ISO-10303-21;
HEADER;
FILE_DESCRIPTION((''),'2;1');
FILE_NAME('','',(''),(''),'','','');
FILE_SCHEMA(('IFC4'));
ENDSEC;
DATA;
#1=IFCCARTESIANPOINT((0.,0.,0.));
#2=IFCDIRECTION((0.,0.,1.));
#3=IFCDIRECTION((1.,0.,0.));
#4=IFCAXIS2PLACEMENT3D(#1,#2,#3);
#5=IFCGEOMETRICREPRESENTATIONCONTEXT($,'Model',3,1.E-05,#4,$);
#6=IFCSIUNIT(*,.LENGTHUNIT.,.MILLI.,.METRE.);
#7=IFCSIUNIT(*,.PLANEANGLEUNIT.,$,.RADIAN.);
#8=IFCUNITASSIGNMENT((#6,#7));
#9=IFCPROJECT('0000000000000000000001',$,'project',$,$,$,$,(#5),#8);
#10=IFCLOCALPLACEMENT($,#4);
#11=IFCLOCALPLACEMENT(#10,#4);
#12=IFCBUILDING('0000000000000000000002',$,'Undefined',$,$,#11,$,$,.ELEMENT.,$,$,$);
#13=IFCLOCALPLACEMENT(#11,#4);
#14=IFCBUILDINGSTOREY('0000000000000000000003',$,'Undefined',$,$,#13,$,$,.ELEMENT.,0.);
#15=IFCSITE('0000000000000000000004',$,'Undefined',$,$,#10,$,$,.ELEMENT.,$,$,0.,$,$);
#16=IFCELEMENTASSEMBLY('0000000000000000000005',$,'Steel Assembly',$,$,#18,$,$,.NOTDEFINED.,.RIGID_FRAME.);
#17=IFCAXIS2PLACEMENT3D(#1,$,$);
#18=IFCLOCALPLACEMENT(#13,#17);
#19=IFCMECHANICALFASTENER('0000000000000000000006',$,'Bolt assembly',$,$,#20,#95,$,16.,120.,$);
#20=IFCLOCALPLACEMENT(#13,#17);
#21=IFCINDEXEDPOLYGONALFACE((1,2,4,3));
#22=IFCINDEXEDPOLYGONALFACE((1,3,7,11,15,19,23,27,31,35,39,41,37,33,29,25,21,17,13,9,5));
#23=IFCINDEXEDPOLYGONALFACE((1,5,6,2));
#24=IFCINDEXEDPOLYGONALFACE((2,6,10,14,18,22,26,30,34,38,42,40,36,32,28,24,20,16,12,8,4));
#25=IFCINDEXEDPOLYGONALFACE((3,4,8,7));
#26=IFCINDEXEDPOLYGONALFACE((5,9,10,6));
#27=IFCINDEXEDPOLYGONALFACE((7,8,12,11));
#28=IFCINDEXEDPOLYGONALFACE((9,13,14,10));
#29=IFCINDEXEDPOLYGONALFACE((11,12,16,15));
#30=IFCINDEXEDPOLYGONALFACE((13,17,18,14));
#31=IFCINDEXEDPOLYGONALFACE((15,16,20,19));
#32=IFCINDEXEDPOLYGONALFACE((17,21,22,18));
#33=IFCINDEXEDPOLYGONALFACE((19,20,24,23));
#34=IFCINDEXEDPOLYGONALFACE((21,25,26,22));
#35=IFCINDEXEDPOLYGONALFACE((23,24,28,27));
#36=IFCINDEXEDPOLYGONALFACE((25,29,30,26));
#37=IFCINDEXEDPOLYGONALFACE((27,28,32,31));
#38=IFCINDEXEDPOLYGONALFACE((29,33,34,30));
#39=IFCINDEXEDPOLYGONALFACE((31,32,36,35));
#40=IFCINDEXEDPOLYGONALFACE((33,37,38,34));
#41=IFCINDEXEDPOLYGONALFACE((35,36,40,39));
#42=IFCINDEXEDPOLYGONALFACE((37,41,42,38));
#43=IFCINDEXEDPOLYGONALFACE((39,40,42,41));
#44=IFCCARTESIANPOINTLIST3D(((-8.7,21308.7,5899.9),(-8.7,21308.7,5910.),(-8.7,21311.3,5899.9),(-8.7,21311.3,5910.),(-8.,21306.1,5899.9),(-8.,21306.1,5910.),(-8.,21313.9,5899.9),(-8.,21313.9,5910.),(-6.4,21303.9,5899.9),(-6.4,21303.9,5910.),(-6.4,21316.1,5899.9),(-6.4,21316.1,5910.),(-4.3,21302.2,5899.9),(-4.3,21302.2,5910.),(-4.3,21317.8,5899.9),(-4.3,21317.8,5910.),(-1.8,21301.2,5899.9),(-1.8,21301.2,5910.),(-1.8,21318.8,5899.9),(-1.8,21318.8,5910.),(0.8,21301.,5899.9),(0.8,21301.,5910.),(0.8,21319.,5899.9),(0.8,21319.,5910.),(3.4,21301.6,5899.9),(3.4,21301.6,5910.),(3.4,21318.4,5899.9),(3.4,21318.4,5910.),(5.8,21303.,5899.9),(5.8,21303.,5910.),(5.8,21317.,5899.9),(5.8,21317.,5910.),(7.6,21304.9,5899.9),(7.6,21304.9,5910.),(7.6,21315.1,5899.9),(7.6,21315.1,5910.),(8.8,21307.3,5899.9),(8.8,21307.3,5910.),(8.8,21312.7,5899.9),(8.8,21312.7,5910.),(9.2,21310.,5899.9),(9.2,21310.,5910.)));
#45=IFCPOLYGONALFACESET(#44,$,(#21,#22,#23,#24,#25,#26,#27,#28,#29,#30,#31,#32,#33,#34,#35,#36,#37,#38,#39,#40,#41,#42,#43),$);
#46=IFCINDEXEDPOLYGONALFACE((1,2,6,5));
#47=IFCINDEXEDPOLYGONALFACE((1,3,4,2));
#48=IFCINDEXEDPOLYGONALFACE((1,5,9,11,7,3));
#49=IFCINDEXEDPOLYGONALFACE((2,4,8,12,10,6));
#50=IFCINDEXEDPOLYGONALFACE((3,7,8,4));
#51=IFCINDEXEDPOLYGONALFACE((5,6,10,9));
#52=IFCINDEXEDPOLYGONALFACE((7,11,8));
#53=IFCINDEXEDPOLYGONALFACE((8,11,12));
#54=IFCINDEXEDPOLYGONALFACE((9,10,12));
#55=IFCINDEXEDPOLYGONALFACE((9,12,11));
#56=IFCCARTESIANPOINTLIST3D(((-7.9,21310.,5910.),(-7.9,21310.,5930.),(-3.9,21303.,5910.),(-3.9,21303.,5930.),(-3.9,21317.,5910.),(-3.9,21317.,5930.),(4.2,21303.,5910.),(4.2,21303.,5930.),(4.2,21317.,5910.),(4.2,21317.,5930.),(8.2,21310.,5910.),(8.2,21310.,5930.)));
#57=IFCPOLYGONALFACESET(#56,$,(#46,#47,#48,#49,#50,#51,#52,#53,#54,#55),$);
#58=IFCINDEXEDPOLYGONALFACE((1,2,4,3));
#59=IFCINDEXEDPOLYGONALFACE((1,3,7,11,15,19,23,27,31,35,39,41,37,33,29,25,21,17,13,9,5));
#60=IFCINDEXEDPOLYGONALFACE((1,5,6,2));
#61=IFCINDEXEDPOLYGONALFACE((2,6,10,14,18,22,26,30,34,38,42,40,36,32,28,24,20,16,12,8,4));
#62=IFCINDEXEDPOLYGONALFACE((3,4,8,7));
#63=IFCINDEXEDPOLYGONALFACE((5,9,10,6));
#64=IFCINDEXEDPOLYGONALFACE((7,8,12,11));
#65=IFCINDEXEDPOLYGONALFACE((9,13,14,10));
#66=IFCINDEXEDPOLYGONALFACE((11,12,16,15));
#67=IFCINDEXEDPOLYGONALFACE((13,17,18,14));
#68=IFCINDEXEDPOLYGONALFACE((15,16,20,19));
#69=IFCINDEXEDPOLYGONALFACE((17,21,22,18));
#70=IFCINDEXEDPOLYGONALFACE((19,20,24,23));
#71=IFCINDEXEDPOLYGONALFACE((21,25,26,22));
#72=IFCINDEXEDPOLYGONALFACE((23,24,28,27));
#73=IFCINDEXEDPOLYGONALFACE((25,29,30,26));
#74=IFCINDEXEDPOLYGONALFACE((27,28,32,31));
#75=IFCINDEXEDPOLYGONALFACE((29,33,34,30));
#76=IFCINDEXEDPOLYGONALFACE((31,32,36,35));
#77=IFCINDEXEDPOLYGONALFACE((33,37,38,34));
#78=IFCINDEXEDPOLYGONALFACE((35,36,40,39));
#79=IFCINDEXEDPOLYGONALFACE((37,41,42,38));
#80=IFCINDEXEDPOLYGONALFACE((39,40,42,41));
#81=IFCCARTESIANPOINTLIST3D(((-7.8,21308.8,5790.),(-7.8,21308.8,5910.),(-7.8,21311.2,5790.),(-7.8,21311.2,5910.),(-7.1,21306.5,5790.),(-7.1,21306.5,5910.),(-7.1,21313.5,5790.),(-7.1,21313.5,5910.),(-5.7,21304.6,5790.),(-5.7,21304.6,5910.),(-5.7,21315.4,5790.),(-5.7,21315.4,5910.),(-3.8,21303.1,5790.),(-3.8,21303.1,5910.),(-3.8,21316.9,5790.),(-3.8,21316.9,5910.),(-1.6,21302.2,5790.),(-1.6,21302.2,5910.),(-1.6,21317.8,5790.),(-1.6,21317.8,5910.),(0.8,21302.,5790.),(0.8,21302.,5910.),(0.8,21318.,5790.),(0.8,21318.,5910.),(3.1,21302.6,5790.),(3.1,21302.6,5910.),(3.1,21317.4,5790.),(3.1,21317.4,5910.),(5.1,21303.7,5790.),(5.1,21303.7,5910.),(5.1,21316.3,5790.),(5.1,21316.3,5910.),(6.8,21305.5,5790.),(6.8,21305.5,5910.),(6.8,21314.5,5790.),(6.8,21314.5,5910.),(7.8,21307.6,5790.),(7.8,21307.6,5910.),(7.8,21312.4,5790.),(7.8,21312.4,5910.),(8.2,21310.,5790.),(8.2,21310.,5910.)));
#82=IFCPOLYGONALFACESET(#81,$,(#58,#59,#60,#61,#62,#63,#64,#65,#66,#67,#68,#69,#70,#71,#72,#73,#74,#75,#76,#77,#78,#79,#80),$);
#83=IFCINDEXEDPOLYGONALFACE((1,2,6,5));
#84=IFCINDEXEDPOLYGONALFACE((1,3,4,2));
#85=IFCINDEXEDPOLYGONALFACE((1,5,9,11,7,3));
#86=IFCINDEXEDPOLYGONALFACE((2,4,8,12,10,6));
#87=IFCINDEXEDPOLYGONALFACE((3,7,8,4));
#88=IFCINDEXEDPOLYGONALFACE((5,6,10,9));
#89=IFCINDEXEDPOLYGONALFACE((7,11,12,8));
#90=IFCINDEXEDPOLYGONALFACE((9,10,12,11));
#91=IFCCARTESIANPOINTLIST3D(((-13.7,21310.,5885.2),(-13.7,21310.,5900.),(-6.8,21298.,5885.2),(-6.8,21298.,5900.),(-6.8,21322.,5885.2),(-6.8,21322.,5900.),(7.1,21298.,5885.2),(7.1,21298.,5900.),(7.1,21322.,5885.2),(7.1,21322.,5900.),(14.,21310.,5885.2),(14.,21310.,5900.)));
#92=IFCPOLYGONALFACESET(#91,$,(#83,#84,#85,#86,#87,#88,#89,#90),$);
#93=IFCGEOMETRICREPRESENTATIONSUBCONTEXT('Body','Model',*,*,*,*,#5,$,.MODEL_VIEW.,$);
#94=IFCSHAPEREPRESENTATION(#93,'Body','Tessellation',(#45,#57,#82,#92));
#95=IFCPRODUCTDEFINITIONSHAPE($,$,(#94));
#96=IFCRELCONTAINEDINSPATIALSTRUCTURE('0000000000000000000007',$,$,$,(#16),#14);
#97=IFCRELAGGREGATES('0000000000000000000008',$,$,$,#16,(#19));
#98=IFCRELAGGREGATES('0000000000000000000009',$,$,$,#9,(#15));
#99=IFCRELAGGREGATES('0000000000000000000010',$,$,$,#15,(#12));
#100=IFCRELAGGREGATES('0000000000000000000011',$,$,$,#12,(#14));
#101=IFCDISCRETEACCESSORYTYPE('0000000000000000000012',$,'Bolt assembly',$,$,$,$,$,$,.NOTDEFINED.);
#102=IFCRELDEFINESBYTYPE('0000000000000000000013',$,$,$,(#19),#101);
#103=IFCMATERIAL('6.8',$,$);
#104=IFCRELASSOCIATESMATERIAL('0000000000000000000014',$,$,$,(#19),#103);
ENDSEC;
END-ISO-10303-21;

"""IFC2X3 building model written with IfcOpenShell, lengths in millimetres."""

from ifc_helpers import new_model, si_unit, frame, origin_with_axes, origin_2d_with_axis, place, context, subcontext, project, spatial, polyline, circle, outline, extrude, source, transform, mapped, material, type_object, element, aggregate, save


model = new_model("IFC2X3")

# Units and contexts
model_context = context("Model", 3, precision=1e-05, world=origin_with_axes())
body_context = subcontext(model_context, "Body", "Model", "MODEL_VIEW")
ifc_project = project(units=[si_unit("LENGTHUNIT", "METRE", prefix="MILLI"), si_unit("PLANEANGLEUNIT", "RADIAN")], contexts=[model_context])

# Site, building, storey
site_placement = place(None, origin_with_axes())
site = spatial("IfcSite", under=ifc_project, at=site_placement, Name="Undefined", CompositionType="ELEMENT", RefElevation=0.0)
building_placement = place(site_placement, origin_with_axes())
building = spatial("IfcBuilding", under=site, at=building_placement, Name="Undefined", CompositionType="ELEMENT")
storey_placement = place(building_placement, origin_with_axes())
storey = spatial("IfcBuildingStorey", under=building, at=storey_placement, Name="Undefined", CompositionType="ELEMENT", Elevation=0.0)

# Element assembly
assembly_1_placement = place(storey_placement, origin_with_axes())
assembly_1 = element("IfcElementAssembly", 1, at=assembly_1_placement, inside=storey, Name="Steel Assembly", AssemblyPlace="NOTDEFINED", PredefinedType="RIGID_FRAME")

# Shared definitions
discrete_accessory_type_1 = type_object("IfcDiscreteAccessoryType", Name="Bolt assembly")

# Mechanical fastener
ifc_material_1 = material(Name="6.8")
shared_shape_1 = source(origin_with_axes(), body_context, "Body", "SweptSolid", [
    extrude(circle(Radius=9.0, at=origin_2d_with_axis()), frame((0.0, -10.0, 0.0), z_axis=(0.0, 1.0, 0.0), x_axis=(1.0, 0.0, 0.0)), (0.0, 0.0, 1.0), 10.1),
    extrude(outline(polyline([(8.1, 0.0), (4.0, 7.0), (-4.0, 7.0), (-8.1, 0.0), (-4.0, -7.0), (4.0, -7.0), (8.1, 0.0)])), frame((0.0, -30.0, 0.0), z_axis=(0.0, 1.0, 0.0), x_axis=(1.0, 0.0, 0.0)), (0.0, 0.0, 1.0), 20.0),
    extrude(circle(Radius=8.0, at=origin_2d_with_axis()), frame((0.0, -10.0, 0.0), z_axis=(0.0, 1.0, 0.0), x_axis=(1.0, 0.0, 0.0)), (0.0, 0.0, 1.0), 120.0),
    extrude(outline(polyline([(13.9, 0.0), (6.9, 12.0), (-6.9, 12.0), (-13.9, 0.0), (-6.9, -12.0), (6.9, -12.0), (13.9, 0.0)])), frame((0.0, 0.0, 0.0), z_axis=(0.0, 1.0, 0.0), x_axis=(1.0, 0.0, 0.0)), (0.0, 0.0, 1.0), 14.8),
])
mechanical_fastener_1_placement = place(assembly_1_placement, frame((0.2, 21310.0, 5900.0), z_axis=(0.0, 1.0, 0.0), x_axis=(1.0, 0.0, 0.0)))
mechanical_fastener_1 = element("IfcMechanicalFastener", 2, at=mechanical_fastener_1_placement, type_object=discrete_accessory_type_1, material=ifc_material_1, Name="Bolt assembly", NominalDiameter=16.0, NominalLength=120.0, context=body_context, shape_type="MappedRepresentation", body=[
    mapped(shared_shape_1, transform((0.0, 0.0, 0.0))),
])
aggregate(assembly_1, [mechanical_fastener_1])

save(model, "model.ifc")
